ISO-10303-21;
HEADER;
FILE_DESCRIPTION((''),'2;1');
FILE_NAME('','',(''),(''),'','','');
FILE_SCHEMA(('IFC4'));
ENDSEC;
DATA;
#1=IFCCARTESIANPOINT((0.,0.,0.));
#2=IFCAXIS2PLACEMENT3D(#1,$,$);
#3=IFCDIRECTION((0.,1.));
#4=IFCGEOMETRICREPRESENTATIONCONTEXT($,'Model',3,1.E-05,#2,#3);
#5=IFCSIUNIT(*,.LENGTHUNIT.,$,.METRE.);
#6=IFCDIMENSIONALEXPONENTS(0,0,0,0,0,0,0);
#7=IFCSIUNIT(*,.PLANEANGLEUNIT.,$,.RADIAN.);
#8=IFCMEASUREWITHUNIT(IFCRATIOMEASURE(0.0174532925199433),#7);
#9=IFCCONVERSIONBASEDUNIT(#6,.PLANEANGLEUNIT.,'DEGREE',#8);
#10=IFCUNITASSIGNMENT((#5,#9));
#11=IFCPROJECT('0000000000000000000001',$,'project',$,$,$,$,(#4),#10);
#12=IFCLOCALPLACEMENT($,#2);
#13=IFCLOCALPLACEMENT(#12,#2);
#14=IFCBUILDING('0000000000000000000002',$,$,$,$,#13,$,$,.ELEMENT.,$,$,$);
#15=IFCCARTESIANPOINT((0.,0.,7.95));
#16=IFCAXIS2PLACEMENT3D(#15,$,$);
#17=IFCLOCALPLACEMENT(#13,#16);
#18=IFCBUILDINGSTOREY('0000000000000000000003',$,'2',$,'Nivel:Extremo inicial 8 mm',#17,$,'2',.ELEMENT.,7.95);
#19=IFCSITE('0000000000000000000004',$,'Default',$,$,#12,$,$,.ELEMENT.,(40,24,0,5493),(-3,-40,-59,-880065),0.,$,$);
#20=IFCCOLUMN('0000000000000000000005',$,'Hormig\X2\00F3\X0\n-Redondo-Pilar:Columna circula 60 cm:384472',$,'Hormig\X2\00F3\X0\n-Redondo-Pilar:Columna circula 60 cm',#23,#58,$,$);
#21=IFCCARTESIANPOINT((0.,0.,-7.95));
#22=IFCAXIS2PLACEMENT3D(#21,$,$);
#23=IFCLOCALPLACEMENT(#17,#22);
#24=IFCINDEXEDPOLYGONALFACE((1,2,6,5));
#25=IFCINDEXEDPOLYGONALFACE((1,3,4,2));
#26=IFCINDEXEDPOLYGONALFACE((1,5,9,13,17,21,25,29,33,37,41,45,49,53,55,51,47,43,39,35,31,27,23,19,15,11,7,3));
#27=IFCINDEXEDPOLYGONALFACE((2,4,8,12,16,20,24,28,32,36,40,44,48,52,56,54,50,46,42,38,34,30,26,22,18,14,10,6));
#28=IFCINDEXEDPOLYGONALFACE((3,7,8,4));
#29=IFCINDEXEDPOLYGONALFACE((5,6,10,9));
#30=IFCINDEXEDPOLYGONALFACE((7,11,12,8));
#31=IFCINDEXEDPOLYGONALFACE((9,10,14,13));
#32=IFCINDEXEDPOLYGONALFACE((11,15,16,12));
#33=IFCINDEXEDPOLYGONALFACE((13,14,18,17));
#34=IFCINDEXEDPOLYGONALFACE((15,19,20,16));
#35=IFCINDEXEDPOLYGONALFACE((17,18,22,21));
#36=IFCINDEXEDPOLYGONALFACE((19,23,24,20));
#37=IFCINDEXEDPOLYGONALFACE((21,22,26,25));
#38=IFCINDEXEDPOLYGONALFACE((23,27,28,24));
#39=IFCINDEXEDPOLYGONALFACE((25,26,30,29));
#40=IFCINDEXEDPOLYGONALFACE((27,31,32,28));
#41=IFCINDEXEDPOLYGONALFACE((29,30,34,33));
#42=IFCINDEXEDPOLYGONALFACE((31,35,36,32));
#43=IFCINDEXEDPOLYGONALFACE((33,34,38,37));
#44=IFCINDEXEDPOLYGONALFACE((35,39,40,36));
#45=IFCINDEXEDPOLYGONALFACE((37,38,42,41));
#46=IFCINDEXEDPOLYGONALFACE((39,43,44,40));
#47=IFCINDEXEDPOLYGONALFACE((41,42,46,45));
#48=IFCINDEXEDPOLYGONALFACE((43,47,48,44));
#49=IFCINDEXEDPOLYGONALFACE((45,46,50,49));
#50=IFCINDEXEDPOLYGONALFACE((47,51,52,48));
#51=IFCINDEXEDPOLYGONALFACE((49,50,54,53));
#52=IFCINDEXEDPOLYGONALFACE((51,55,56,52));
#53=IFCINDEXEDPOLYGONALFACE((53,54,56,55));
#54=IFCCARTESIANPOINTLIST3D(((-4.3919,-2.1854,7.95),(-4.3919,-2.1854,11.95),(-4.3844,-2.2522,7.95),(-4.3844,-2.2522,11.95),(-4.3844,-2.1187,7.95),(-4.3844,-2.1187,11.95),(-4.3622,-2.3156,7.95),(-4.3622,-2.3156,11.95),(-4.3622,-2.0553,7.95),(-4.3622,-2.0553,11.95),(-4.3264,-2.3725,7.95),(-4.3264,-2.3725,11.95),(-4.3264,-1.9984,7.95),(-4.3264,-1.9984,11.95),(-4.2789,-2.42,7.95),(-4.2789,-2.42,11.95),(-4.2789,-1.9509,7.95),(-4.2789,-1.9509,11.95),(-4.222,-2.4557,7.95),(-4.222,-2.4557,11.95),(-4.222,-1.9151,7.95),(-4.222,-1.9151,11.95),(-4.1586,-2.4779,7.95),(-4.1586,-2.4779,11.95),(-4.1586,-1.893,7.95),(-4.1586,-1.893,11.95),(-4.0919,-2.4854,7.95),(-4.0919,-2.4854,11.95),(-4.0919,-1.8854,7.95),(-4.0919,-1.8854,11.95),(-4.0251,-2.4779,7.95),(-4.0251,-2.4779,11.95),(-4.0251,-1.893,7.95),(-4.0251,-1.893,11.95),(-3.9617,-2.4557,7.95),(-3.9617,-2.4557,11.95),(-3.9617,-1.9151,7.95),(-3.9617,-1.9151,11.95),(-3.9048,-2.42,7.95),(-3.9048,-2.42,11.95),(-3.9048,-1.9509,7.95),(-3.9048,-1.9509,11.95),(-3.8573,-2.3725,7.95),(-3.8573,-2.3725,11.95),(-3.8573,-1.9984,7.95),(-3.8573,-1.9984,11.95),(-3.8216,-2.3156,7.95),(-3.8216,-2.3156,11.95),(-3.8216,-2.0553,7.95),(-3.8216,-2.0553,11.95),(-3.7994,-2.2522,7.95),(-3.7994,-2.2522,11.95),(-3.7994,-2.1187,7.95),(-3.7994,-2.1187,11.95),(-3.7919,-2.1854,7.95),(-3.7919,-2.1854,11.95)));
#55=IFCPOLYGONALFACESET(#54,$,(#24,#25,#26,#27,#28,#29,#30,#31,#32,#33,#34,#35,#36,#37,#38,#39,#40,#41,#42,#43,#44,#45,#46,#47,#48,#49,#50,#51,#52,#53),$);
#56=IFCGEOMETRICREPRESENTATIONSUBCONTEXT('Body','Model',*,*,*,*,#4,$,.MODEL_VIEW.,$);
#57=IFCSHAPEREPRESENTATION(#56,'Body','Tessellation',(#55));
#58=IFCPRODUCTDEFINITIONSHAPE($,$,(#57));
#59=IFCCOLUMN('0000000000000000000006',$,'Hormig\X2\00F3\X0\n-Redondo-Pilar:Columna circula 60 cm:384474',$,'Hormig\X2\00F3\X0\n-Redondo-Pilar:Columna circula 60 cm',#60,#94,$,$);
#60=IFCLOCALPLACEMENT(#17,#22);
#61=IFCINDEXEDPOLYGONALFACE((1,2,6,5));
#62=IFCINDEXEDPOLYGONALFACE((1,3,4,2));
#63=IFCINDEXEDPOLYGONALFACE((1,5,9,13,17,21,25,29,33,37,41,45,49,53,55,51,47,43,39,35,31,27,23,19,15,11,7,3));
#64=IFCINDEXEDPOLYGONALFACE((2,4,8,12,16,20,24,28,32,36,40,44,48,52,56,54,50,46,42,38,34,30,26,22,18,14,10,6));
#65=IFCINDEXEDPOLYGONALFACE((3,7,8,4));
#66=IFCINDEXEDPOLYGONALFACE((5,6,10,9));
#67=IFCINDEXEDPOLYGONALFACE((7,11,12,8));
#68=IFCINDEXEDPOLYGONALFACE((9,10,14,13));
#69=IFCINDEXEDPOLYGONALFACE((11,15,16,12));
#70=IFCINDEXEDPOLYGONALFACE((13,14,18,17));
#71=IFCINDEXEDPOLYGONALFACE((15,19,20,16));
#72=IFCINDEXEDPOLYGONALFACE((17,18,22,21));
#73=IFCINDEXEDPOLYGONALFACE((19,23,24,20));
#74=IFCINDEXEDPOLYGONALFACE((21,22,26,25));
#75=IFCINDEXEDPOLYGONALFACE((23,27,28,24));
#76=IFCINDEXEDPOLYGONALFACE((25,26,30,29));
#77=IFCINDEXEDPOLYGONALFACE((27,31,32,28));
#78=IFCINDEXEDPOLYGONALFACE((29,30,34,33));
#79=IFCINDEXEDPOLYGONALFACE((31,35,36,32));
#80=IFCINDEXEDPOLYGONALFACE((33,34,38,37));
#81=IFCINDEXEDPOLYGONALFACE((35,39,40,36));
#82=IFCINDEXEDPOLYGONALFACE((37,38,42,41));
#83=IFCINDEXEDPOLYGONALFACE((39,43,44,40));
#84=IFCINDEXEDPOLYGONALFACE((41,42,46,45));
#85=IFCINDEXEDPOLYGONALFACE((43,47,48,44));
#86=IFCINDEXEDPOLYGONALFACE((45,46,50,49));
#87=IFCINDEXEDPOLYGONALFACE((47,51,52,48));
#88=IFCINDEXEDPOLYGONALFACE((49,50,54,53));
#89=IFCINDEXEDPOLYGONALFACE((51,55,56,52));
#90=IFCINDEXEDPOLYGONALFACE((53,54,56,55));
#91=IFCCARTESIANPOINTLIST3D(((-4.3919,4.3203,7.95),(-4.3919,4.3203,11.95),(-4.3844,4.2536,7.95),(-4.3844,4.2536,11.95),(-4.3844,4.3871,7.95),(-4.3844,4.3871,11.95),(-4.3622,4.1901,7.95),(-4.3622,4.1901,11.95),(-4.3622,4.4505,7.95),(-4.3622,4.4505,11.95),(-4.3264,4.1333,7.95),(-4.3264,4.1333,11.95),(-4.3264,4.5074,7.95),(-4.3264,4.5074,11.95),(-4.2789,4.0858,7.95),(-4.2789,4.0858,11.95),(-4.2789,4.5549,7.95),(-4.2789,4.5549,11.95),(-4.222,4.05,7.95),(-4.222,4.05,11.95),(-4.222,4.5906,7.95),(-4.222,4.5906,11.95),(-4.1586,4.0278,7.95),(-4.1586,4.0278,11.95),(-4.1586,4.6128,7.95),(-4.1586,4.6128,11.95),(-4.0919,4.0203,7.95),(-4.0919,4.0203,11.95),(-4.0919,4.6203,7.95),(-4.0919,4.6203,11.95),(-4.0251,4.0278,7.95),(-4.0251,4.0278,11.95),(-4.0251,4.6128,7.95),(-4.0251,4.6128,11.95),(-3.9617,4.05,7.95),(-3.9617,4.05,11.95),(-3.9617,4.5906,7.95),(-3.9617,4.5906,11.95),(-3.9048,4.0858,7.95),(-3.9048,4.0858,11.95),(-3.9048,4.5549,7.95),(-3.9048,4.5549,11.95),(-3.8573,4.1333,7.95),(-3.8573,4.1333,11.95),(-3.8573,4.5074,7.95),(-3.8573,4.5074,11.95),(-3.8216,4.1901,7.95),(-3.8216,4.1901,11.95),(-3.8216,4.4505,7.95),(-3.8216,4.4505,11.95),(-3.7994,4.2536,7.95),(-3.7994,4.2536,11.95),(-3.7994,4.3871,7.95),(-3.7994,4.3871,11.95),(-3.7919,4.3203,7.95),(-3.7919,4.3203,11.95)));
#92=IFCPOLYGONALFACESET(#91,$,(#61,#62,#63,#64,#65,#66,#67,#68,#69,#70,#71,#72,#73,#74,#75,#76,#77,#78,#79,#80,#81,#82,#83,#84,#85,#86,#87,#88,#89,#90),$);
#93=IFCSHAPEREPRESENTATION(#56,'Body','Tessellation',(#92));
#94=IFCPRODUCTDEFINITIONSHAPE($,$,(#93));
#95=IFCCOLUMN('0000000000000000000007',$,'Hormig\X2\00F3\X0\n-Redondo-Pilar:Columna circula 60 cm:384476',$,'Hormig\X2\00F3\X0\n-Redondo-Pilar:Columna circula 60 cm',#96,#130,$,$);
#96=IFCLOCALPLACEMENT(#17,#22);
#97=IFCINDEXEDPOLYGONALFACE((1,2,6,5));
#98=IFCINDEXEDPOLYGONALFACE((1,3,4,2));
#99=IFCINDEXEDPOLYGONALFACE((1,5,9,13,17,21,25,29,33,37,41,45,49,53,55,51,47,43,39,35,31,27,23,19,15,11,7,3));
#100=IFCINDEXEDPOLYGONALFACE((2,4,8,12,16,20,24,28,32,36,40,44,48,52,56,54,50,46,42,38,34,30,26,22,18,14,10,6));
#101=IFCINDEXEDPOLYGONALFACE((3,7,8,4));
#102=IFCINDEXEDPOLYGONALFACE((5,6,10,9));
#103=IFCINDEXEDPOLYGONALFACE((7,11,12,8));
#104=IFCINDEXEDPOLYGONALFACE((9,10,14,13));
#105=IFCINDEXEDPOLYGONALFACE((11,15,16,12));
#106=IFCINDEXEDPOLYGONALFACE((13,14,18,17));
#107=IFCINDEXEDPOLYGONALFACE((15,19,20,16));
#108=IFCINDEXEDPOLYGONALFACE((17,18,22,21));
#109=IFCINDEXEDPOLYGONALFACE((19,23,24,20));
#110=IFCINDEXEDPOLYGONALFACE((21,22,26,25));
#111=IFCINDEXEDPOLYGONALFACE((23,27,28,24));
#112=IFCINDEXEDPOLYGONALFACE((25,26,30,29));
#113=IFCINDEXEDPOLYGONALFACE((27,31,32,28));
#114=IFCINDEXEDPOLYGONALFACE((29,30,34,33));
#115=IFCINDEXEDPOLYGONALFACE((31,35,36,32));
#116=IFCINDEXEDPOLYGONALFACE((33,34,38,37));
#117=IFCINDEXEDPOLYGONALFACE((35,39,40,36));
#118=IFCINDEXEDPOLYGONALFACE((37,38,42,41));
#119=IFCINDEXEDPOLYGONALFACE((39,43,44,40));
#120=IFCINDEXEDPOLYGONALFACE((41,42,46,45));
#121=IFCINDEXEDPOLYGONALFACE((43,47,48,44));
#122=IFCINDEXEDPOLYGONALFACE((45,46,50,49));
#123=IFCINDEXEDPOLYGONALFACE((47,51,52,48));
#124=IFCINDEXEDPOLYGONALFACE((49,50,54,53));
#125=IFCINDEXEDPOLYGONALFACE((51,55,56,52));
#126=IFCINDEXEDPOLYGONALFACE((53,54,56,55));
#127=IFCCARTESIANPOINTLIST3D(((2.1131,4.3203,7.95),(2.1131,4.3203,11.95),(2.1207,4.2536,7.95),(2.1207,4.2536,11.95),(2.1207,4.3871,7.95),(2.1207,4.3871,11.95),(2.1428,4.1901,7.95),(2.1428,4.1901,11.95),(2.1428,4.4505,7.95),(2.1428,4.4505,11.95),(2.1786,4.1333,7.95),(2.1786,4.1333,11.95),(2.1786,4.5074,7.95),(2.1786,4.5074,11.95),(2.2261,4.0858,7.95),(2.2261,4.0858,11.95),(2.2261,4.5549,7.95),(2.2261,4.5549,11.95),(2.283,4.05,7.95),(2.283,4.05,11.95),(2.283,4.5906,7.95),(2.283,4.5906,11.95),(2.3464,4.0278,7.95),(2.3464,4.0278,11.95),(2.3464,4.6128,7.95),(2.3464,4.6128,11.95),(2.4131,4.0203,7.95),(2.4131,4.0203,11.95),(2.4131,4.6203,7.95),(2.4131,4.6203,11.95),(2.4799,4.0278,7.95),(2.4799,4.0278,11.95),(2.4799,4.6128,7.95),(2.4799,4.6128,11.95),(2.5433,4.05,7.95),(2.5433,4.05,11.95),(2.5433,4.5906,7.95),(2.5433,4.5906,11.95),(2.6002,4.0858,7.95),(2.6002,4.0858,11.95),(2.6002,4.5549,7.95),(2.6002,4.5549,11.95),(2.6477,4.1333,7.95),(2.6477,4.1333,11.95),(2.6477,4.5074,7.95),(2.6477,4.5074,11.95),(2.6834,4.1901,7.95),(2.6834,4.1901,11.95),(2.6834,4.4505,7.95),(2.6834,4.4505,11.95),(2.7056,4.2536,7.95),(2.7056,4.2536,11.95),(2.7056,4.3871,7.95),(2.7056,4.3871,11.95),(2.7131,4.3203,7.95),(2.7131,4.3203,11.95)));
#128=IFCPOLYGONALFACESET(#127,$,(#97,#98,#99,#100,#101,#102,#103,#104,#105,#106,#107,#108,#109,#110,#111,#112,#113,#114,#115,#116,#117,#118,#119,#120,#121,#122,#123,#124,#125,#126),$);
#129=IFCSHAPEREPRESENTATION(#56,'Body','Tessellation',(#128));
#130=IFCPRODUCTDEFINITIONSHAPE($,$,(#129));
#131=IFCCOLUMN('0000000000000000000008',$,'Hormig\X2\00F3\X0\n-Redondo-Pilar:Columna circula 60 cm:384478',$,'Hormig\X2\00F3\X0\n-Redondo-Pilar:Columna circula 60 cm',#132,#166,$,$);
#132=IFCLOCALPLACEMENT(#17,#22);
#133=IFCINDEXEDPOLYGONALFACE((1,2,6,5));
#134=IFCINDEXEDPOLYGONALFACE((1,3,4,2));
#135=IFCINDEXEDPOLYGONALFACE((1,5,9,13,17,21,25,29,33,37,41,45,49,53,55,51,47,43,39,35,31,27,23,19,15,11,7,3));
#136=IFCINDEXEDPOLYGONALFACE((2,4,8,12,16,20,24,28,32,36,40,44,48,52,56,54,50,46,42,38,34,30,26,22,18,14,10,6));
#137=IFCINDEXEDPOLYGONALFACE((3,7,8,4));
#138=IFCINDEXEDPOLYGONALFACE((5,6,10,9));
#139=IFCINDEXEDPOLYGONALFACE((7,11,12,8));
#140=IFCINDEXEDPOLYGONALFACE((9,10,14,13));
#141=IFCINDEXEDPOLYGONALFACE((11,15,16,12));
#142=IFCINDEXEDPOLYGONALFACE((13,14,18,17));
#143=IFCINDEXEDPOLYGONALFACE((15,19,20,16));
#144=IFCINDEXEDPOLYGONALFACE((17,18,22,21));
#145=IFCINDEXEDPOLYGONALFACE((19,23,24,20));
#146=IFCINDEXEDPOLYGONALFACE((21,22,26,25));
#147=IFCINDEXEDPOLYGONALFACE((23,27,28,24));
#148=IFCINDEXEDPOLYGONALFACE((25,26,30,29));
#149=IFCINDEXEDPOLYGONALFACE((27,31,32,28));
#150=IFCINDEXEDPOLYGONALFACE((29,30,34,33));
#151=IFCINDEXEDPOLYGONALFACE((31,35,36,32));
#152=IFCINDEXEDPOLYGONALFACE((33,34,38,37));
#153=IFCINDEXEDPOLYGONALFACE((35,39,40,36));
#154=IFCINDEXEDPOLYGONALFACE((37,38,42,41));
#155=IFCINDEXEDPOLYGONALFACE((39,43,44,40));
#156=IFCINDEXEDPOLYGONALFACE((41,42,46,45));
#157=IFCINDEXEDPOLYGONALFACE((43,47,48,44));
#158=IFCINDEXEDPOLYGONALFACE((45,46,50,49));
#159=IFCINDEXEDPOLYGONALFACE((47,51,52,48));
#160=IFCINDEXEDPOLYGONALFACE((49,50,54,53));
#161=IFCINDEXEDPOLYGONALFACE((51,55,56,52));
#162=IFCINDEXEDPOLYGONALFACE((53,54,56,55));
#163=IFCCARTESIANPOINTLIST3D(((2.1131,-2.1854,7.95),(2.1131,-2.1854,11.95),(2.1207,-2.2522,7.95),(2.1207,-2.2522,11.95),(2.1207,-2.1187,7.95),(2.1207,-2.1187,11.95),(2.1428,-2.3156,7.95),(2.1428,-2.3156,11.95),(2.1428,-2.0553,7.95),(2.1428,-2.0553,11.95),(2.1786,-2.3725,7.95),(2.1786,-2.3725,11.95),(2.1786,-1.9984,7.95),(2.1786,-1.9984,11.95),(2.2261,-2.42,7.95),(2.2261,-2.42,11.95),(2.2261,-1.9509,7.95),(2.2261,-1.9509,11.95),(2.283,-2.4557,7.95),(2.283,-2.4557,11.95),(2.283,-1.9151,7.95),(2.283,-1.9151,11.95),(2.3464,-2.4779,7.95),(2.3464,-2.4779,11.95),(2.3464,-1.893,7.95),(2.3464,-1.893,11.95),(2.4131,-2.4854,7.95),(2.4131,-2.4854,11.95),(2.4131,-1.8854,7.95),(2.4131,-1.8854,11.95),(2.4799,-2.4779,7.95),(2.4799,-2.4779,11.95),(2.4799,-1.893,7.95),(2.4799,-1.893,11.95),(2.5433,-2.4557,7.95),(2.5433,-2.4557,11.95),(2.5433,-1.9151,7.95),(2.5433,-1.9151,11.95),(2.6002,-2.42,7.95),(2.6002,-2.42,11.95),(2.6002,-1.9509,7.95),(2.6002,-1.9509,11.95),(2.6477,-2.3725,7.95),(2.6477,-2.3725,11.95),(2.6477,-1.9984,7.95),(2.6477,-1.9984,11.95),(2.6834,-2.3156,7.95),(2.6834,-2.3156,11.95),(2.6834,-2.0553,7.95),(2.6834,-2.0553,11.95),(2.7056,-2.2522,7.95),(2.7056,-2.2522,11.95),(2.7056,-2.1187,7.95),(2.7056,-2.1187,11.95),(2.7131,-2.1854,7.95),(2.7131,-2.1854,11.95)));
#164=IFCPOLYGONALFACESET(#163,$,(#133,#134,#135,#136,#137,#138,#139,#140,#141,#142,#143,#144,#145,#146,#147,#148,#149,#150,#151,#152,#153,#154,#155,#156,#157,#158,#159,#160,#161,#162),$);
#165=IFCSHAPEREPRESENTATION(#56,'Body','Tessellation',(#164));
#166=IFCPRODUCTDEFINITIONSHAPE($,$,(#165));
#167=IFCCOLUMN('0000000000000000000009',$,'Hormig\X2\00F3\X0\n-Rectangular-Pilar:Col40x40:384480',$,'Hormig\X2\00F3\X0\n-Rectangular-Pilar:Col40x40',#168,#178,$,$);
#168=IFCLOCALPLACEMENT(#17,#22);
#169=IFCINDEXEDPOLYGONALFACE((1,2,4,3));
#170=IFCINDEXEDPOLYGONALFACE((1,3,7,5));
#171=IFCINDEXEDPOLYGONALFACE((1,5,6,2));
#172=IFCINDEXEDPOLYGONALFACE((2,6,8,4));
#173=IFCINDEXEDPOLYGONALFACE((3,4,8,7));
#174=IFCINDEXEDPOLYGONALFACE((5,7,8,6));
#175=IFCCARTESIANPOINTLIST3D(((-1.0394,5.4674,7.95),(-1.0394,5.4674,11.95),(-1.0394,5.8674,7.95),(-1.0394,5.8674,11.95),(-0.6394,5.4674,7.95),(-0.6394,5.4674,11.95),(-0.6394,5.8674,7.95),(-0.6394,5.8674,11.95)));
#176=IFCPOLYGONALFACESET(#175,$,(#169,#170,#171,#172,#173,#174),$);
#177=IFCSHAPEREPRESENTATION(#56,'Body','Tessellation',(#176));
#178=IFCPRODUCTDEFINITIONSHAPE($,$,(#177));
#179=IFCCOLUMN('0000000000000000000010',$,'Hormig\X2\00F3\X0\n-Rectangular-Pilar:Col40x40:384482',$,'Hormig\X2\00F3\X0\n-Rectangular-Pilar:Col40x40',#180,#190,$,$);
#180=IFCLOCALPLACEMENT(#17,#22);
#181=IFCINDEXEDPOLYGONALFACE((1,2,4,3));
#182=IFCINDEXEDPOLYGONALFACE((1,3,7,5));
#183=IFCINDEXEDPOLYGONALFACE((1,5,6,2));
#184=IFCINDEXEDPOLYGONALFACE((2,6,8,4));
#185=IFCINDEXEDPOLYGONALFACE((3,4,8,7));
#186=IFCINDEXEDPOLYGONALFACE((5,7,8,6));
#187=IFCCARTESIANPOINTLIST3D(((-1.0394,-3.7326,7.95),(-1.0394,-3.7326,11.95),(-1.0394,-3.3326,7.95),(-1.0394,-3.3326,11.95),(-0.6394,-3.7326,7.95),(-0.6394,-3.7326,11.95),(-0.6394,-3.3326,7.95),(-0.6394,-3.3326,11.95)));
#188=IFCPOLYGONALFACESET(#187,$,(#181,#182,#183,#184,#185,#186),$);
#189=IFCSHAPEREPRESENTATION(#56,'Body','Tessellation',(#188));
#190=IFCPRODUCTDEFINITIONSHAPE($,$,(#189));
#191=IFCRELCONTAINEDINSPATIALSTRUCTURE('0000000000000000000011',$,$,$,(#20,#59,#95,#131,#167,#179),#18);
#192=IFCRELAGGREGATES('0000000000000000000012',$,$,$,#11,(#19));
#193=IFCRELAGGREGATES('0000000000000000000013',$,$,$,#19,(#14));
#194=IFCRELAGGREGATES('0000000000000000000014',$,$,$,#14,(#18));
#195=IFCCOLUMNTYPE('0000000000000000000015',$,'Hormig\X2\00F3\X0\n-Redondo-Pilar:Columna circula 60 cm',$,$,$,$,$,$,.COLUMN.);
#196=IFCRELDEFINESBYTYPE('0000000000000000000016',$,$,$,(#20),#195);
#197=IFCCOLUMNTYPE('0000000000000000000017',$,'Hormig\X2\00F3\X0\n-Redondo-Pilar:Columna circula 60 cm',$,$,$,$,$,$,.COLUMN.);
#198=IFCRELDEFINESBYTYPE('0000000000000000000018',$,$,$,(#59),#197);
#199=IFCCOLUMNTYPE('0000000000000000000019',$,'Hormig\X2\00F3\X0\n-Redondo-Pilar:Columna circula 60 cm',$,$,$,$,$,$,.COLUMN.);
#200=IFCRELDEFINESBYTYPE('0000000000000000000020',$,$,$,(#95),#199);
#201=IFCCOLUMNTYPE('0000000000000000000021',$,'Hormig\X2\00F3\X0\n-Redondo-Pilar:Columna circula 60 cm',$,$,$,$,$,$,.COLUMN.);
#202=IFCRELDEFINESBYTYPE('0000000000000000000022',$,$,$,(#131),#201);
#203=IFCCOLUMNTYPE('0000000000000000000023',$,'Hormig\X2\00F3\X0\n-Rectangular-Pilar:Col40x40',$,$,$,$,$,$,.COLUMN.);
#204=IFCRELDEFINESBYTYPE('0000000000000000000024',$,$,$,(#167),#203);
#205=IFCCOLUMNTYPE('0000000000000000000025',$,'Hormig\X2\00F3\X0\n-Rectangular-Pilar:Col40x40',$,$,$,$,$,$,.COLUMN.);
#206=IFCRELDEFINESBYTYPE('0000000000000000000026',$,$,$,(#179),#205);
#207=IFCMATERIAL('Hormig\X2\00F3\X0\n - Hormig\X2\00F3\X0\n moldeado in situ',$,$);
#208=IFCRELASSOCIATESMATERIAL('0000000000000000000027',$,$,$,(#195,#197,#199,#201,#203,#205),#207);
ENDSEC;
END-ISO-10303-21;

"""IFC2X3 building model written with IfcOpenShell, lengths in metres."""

from ifc_helpers import new_model, entity, si_unit, converted_unit, direction, frame, frame_2d, origin, origin_2d_with_axis, place, context, subcontext, project, spatial, rectangle, circle, extrude, source, transform, mapped, material, type_object, type_shapes, element, save


model = new_model("IFC2X3")

# Units and contexts
model_context = context("Model", 3, precision=1e-05, world=origin(), true_north=direction((0.0, 1.0)))
body_context = subcontext(model_context, "Body", "Model", "MODEL_VIEW")
ifc_project = project(units=[si_unit("LENGTHUNIT", "METRE"), converted_unit("PLANEANGLEUNIT", "DEGREE", entity("IfcRatioMeasure", 0.0174532925199433), si_unit("PLANEANGLEUNIT", "RADIAN"), dimensions=[0, 0, 0, 0, 0, 0, 0])], contexts=[model_context])

# Site, building, storey
site_placement = place(None, origin())
site = spatial("IfcSite", under=ifc_project, at=site_placement, Name="Default", CompositionType="ELEMENT", RefLatitude=(40, 24, 0, 5493), RefLongitude=(-3, -40, -59, -880065), RefElevation=0.0)
building_placement = place(site_placement, origin())
building = spatial("IfcBuilding", under=site, at=building_placement, CompositionType="ELEMENT")
storey_placement = place(building_placement, frame((0.0, 0.0, 7.95)))
storey = spatial("IfcBuildingStorey", under=building, at=storey_placement, Name="2", ObjectType="Nivel:Extremo inicial 8 mm", LongName="2", CompositionType="ELEMENT", Elevation=7.95)

# Columns
ifc_material_1 = material(Name="Hormigón - Hormigón moldeado in situ")
column_type_1 = type_object("IfcColumnType", Name="Hormigón-Redondo-Pilar:Columna circula 60 cm", PredefinedType="COLUMN", material=ifc_material_1)
shared_shape_1 = source(origin(), body_context, "Body", "SweptSolid", [
    extrude(circle(Radius=0.3, at=frame_2d((0.0, 0.0), x_axis=(1.0, 0.0))), frame((-4.0919, -2.1854, 7.95)), (0.0, 0.0, 1.0), 4.0),
])
type_shapes(column_type_1, [shared_shape_1])
column_1_placement = place(storey_placement, frame((0.0, 0.0, -7.95)))
element("IfcColumn", 1, at=column_1_placement, inside=storey, type_object=column_type_1, Name="Hormigón-Redondo-Pilar:Columna circula 60 cm:384472", ObjectType="Hormigón-Redondo-Pilar:Columna circula 60 cm", context=body_context, shape_type="MappedRepresentation", body=[
    mapped(shared_shape_1, transform((0.0, 0.0, 0.0), scale=1.0)),
])
column_type_2 = type_object("IfcColumnType", Name="Hormigón-Redondo-Pilar:Columna circula 60 cm", PredefinedType="COLUMN", material=ifc_material_1)
shared_shape_2 = source(origin(), body_context, "Body", "SweptSolid", [
    extrude(circle(Radius=0.3, at=frame_2d((0.0, 0.0), x_axis=(1.0, 0.0))), frame((-4.0919, 4.3203, 7.95)), (0.0, 0.0, 1.0), 4.0),
])
type_shapes(column_type_2, [shared_shape_2])
column_2_placement = place(storey_placement, frame((0.0, 0.0, -7.95)))
element("IfcColumn", 2, at=column_2_placement, inside=storey, type_object=column_type_2, Name="Hormigón-Redondo-Pilar:Columna circula 60 cm:384474", ObjectType="Hormigón-Redondo-Pilar:Columna circula 60 cm", context=body_context, shape_type="MappedRepresentation", body=[
    mapped(shared_shape_2, transform((0.0, 0.0, 0.0), scale=1.0)),
])
column_type_3 = type_object("IfcColumnType", Name="Hormigón-Redondo-Pilar:Columna circula 60 cm", PredefinedType="COLUMN", material=ifc_material_1)
shared_shape_3 = source(origin(), body_context, "Body", "SweptSolid", [
    extrude(circle(Radius=0.3, at=frame_2d((0.0, 0.0), x_axis=(1.0, 0.0))), frame((2.4131, 4.3203, 7.95)), (0.0, 0.0, 1.0), 4.0),
])
type_shapes(column_type_3, [shared_shape_3])
column_3_placement = place(storey_placement, frame((0.0, 0.0, -7.95)))
element("IfcColumn", 3, at=column_3_placement, inside=storey, type_object=column_type_3, Name="Hormigón-Redondo-Pilar:Columna circula 60 cm:384476", ObjectType="Hormigón-Redondo-Pilar:Columna circula 60 cm", context=body_context, shape_type="MappedRepresentation", body=[
    mapped(shared_shape_3, transform((0.0, 0.0, 0.0), scale=1.0)),
])
column_type_4 = type_object("IfcColumnType", Name="Hormigón-Redondo-Pilar:Columna circula 60 cm", PredefinedType="COLUMN", material=ifc_material_1)
shared_shape_4 = source(origin(), body_context, "Body", "SweptSolid", [
    extrude(circle(Radius=0.3, at=frame_2d((0.0, 0.0), x_axis=(1.0, 0.0))), frame((2.4131, -2.1854, 7.95)), (0.0, 0.0, 1.0), 4.0),
])
type_shapes(column_type_4, [shared_shape_4])
column_4_placement = place(storey_placement, frame((0.0, 0.0, -7.95)))
element("IfcColumn", 4, at=column_4_placement, inside=storey, type_object=column_type_4, Name="Hormigón-Redondo-Pilar:Columna circula 60 cm:384478", ObjectType="Hormigón-Redondo-Pilar:Columna circula 60 cm", context=body_context, shape_type="MappedRepresentation", body=[
    mapped(shared_shape_4, transform((0.0, 0.0, 0.0), scale=1.0)),
])
column_type_5 = type_object("IfcColumnType", Name="Hormigón-Rectangular-Pilar:Col40x40", PredefinedType="COLUMN", material=ifc_material_1)
shared_shape_5 = source(origin(), body_context, "Body", "SweptSolid", [
    extrude(rectangle(XDim=0.4, YDim=0.4, at=origin_2d_with_axis()), frame((-0.8394, 5.6674, 7.95), z_axis=(0.0, 0.0, 1.0), x_axis=(0.0, -1.0, 0.0)), (0.0, 0.0, 1.0), 4.0),
])
type_shapes(column_type_5, [shared_shape_5])
column_5_placement = place(storey_placement, frame((0.0, 0.0, -7.95)))
element("IfcColumn", 5, at=column_5_placement, inside=storey, type_object=column_type_5, Name="Hormigón-Rectangular-Pilar:Col40x40:384480", ObjectType="Hormigón-Rectangular-Pilar:Col40x40", context=body_context, shape_type="MappedRepresentation", body=[
    mapped(shared_shape_5, transform((0.0, 0.0, 0.0), scale=1.0)),
])
column_type_6 = type_object("IfcColumnType", Name="Hormigón-Rectangular-Pilar:Col40x40", PredefinedType="COLUMN", material=ifc_material_1)
shared_shape_6 = source(origin(), body_context, "Body", "SweptSolid", [
    extrude(rectangle(XDim=0.4, YDim=0.4, at=origin_2d_with_axis()), frame((-0.8394, -3.5326, 7.95), z_axis=(0.0, 0.0, 1.0), x_axis=(0.0, -1.0, 0.0)), (0.0, 0.0, 1.0), 4.0),
])
type_shapes(column_type_6, [shared_shape_6])
column_6_placement = place(storey_placement, frame((0.0, 0.0, -7.95)))
element("IfcColumn", 6, at=column_6_placement, inside=storey, type_object=column_type_6, Name="Hormigón-Rectangular-Pilar:Col40x40:384482", ObjectType="Hormigón-Rectangular-Pilar:Col40x40", context=body_context, shape_type="MappedRepresentation", body=[
    mapped(shared_shape_6, transform((0.0, 0.0, 0.0), scale=1.0)),
])

save(model, "model.ifc")
